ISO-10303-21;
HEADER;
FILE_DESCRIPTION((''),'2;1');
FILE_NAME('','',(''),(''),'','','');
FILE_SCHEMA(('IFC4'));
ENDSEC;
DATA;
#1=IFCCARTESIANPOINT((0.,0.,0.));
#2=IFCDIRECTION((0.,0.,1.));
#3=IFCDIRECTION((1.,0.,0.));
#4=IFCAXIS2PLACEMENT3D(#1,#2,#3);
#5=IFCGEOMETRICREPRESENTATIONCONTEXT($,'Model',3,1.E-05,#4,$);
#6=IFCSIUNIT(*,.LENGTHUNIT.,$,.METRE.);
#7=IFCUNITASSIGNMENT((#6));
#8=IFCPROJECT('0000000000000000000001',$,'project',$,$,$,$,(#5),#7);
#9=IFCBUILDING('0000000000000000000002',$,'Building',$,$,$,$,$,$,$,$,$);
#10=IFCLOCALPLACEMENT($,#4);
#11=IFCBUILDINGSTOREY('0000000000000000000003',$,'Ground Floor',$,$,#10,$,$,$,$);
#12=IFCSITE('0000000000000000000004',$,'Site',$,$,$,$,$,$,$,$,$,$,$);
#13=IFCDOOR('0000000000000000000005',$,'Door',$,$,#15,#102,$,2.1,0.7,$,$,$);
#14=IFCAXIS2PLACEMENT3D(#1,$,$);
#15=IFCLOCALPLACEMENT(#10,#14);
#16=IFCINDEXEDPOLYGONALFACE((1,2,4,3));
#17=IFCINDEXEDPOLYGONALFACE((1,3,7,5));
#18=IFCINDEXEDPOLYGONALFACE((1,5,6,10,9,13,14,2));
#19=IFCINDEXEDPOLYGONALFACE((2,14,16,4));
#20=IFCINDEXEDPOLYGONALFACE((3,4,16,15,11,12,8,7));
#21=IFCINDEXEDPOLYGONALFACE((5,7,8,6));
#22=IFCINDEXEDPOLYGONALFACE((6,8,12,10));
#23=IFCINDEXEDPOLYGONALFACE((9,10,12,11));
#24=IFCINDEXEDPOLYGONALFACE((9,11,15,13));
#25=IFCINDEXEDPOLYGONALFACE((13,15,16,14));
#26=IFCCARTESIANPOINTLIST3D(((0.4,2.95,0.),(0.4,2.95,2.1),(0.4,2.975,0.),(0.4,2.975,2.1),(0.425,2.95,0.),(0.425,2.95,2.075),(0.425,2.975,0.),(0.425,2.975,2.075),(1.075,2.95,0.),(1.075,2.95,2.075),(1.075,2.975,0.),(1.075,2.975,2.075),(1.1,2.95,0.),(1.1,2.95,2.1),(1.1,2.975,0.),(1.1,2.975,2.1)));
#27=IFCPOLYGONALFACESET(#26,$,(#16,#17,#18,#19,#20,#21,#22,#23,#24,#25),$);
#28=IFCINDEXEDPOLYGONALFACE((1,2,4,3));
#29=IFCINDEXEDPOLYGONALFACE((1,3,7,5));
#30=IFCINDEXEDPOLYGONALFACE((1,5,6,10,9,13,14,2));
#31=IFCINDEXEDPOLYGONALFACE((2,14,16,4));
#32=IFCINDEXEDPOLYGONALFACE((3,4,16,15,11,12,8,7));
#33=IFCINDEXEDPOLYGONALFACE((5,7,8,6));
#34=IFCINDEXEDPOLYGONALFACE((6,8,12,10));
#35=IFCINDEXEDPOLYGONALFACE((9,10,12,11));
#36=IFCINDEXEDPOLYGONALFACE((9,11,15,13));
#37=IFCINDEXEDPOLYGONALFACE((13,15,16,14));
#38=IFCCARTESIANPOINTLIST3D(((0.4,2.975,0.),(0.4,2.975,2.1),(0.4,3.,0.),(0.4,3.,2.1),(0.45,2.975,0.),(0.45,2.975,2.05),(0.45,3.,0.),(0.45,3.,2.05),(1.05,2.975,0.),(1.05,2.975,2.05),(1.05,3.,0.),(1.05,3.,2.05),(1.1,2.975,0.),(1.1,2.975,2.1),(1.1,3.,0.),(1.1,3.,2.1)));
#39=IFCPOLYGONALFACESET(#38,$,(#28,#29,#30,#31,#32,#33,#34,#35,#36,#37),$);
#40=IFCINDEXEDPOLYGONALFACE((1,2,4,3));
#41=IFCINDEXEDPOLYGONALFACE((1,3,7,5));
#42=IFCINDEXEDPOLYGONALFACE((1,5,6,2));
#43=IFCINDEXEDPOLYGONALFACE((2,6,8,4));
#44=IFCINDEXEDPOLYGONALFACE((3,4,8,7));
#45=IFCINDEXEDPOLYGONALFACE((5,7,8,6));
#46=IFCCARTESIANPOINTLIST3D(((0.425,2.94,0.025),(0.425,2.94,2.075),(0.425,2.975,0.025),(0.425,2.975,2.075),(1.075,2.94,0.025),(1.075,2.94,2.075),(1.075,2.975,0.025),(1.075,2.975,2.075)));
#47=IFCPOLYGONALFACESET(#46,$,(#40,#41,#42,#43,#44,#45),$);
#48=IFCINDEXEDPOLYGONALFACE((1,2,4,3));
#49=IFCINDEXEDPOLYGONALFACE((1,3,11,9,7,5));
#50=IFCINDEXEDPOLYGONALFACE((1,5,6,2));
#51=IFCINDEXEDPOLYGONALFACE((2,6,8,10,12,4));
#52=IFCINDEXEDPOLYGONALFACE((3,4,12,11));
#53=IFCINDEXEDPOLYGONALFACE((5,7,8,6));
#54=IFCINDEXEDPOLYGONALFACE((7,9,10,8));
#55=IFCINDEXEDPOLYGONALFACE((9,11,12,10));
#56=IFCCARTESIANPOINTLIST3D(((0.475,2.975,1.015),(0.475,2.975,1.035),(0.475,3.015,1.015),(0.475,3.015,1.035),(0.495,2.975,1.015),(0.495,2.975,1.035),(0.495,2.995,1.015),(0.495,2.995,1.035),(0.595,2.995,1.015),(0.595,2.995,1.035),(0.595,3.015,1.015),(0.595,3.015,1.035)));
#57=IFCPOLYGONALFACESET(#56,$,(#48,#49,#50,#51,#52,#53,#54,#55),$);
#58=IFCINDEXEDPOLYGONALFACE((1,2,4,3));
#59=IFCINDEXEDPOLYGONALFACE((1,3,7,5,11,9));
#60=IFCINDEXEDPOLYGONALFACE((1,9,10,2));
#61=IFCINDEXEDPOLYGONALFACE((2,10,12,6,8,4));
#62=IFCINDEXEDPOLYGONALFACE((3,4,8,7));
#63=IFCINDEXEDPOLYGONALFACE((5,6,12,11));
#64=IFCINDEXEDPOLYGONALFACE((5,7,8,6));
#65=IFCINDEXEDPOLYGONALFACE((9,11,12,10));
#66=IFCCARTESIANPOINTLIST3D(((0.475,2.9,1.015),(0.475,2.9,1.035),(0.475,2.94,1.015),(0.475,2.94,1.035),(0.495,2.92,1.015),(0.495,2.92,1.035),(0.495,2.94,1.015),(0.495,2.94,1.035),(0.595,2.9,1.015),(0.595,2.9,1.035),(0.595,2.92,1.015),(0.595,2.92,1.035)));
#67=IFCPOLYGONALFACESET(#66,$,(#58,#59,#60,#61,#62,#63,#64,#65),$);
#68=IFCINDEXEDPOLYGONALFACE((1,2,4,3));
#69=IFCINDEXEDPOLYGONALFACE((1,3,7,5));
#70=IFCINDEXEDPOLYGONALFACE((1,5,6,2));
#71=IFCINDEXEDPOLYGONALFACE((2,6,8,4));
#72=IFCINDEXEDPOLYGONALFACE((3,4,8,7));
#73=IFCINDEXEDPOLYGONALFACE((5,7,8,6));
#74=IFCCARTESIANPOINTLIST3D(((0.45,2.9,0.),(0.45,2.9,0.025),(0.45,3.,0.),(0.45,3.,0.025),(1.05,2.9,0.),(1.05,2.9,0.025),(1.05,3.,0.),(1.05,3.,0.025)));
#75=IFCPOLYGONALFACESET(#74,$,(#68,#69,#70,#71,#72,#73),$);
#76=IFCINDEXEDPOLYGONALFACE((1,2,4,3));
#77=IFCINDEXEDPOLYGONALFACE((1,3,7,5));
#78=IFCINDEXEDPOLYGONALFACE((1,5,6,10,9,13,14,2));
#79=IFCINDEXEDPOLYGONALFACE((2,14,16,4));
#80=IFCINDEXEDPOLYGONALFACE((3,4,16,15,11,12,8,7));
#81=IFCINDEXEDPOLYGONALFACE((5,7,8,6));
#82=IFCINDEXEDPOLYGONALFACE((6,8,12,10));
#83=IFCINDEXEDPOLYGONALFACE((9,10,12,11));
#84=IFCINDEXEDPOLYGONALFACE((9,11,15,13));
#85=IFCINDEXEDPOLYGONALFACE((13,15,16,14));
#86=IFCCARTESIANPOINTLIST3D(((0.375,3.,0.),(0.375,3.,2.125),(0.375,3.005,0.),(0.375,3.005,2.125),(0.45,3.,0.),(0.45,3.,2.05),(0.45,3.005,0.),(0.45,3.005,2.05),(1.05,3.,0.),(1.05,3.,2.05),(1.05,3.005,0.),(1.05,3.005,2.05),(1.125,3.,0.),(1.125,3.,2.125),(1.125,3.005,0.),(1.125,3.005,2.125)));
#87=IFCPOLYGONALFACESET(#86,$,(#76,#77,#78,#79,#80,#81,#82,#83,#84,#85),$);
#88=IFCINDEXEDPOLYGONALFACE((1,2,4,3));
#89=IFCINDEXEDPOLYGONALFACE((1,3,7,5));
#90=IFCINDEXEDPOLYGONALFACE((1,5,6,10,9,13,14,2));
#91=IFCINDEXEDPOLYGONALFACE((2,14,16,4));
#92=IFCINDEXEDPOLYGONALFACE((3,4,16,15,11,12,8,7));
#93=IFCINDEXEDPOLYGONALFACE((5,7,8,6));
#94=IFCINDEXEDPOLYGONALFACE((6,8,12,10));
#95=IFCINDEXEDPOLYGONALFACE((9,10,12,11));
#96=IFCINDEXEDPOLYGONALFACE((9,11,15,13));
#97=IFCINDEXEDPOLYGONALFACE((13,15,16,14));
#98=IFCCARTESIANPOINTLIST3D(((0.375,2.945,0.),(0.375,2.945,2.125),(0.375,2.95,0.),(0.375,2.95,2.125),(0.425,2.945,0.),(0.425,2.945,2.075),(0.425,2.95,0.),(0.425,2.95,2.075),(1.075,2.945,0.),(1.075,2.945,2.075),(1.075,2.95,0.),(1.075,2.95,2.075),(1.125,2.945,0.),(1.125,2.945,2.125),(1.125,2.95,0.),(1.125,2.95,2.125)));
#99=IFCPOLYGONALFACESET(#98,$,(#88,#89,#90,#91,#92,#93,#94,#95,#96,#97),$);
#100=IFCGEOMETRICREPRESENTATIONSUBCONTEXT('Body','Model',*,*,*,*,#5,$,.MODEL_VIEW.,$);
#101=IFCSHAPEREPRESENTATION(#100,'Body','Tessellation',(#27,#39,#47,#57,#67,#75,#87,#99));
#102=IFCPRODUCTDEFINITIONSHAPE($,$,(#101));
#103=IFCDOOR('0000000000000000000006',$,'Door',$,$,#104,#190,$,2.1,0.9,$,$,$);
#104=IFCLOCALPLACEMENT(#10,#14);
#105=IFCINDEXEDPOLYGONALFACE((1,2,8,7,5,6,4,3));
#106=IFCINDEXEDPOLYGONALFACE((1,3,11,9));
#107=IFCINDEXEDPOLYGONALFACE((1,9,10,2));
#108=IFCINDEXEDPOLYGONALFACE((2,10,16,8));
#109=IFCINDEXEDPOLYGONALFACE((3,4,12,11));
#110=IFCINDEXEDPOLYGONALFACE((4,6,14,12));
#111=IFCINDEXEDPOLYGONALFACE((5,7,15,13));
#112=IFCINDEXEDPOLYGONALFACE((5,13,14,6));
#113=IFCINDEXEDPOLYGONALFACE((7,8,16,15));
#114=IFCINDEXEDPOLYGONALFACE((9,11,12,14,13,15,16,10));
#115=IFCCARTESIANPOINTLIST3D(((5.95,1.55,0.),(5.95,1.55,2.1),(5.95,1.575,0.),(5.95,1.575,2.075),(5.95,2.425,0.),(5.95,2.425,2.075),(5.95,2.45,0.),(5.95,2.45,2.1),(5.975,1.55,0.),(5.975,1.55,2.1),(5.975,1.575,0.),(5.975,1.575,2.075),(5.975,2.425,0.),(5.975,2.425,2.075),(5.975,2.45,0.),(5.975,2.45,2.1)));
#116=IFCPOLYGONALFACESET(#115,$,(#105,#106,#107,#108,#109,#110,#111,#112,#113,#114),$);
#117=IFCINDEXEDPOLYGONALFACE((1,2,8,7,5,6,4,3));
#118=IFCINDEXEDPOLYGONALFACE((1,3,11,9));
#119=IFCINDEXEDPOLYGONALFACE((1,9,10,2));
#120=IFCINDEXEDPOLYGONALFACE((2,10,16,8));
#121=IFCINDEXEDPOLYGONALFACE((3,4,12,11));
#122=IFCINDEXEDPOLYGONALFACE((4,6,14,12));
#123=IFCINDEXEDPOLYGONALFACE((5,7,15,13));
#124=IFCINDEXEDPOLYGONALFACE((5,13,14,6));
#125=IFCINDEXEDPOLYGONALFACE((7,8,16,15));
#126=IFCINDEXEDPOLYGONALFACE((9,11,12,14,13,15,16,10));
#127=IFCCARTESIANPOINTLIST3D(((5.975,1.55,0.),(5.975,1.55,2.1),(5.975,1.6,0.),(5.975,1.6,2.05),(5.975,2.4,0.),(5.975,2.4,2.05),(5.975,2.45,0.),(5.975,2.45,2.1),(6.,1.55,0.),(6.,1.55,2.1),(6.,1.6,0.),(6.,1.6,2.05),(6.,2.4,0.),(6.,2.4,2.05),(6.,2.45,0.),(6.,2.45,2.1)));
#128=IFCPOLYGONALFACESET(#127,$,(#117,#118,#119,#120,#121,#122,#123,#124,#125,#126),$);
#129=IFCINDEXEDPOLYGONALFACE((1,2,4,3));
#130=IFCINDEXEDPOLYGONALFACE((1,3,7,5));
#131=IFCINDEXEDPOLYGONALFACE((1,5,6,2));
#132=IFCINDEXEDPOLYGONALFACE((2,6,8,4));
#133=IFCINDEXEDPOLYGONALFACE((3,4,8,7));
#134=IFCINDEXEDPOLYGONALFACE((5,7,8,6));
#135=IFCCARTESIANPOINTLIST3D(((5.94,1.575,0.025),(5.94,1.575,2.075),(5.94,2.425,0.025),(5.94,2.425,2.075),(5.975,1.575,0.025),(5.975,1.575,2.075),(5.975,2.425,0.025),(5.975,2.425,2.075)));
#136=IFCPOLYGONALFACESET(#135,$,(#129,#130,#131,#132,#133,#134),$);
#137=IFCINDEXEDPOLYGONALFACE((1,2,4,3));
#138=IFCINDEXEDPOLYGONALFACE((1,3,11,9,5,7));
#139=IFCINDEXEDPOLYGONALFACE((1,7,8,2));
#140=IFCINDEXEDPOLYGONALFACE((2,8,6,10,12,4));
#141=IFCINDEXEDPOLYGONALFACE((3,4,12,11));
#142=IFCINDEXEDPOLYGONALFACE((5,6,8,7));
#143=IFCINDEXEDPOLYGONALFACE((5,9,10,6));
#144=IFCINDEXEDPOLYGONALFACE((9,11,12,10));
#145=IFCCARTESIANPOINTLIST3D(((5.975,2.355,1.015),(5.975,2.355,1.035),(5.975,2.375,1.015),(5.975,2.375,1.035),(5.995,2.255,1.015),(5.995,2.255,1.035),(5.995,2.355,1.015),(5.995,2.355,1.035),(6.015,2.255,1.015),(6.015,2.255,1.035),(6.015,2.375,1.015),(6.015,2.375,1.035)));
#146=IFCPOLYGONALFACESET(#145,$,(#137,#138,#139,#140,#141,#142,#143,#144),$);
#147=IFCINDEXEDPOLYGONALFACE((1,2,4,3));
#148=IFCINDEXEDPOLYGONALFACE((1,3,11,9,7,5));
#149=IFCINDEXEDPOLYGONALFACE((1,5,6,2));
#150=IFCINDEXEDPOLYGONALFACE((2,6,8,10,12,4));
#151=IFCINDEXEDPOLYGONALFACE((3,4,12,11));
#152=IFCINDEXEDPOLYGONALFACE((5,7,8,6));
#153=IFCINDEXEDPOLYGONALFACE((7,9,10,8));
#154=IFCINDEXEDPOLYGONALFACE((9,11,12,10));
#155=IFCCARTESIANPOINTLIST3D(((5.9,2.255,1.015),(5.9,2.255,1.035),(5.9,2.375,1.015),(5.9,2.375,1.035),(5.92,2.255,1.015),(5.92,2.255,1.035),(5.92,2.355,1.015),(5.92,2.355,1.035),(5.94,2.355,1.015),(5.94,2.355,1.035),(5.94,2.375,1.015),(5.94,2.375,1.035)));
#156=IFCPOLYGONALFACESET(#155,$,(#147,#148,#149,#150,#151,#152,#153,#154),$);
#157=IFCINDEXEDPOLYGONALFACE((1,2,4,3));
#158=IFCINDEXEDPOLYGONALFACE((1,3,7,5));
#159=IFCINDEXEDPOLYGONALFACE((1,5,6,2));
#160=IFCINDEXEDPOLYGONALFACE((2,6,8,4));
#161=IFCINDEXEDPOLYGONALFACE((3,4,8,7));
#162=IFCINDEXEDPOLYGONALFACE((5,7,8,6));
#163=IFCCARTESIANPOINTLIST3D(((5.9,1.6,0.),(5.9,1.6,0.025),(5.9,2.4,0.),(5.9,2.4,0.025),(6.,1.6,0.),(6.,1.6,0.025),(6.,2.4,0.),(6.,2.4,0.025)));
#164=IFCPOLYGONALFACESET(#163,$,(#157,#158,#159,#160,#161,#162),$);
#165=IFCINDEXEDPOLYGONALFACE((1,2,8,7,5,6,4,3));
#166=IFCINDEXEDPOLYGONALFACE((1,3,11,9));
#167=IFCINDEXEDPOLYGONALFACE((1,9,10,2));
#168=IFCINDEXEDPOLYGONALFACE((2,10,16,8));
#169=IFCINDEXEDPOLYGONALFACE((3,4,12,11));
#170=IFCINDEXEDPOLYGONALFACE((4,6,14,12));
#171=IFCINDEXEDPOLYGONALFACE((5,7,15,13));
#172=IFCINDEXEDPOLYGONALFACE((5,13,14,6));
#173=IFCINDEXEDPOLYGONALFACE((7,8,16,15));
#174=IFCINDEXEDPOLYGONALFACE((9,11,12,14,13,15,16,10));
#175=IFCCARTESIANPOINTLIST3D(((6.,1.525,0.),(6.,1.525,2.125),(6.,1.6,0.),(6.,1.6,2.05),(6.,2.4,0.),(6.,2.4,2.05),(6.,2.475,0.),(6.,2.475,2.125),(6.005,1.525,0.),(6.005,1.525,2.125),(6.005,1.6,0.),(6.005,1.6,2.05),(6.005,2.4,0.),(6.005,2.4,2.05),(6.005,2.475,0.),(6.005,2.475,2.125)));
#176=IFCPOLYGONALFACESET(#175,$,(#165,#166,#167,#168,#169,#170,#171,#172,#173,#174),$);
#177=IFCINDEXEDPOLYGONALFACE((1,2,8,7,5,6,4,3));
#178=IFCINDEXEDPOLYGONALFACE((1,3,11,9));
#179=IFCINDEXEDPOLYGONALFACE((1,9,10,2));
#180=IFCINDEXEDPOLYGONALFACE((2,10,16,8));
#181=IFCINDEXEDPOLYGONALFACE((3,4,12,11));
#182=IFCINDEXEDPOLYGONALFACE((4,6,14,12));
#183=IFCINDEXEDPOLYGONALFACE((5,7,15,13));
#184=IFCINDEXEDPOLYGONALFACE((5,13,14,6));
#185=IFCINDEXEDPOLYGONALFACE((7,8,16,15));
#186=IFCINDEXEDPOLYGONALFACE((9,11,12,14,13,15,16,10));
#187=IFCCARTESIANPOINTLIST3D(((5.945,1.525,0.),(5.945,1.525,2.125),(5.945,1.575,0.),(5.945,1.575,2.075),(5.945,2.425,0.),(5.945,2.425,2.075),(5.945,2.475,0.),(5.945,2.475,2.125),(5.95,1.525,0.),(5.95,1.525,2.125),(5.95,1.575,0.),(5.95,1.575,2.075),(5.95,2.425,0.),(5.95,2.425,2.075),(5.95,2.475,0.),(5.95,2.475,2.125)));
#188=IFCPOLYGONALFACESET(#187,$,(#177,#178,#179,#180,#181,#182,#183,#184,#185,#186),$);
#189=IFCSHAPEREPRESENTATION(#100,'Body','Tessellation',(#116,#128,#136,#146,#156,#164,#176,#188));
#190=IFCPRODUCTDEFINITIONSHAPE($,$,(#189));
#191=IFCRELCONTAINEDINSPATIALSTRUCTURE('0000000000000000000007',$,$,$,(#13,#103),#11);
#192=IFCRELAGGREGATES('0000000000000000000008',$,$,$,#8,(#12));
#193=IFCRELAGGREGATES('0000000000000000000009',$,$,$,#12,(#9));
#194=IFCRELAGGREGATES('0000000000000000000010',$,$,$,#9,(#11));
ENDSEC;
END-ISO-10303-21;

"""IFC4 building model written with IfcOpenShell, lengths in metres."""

from ifc_helpers import new_model, si_unit, frame, origin_with_axes, place, context, subcontext, project, spatial, line, indexed_curve, outline, extrude, element, save


model = new_model("IFC4")

# Units and contexts
model_context = context("Model", 3, precision=1e-05, world=origin_with_axes())
body_context = subcontext(model_context, "Body", "Model", "MODEL_VIEW")
ifc_project = project(units=[si_unit("LENGTHUNIT", "METRE")], contexts=[model_context])

# Site, building, storey
site = spatial("IfcSite", under=ifc_project, Name="Site")
building = spatial("IfcBuilding", under=site, Name="Building")
storey_placement = place(None, origin_with_axes())
storey = spatial("IfcBuildingStorey", under=building, at=storey_placement, Name="Ground Floor")

# Doors
door_1_placement = place(storey_placement, frame((1.1, 3.0, 0.0), z_axis=(0.0, 0.0, 1.0), x_axis=(-1.0, 0.0, 0.0)))
element("IfcDoor", 1, at=door_1_placement, inside=storey, Name="Door", OverallHeight=2.1, OverallWidth=0.7, context=body_context, shape_type="SweptSolid", body=[
    extrude(outline(indexed_curve([(0.0, 0.0), (0.0, 2.1), (0.7, 2.1), (0.7, 0.0), (0.675, 0.0), (0.675, 2.075), (0.025, 2.075), (0.025, 0.0)], segments=[line(1, 2, 3, 4, 5, 6, 7, 8, 1)])), frame((0.0, 0.025, 0.0), z_axis=(0.0, -1.0, 0.0), x_axis=(1.0, 0.0, 0.0)), (0.0, 0.0, -1.0), 0.025),
    extrude(outline(indexed_curve([(0.0, 0.0), (0.0, 2.1), (0.7, 2.1), (0.7, 0.0), (0.65, 0.0), (0.65, 2.05), (0.05, 2.05), (0.05, 0.0)], segments=[line(1, 2, 3, 4, 5, 6, 7, 8, 1)])), frame((0.0, 0.0, 0.0), z_axis=(0.0, -1.0, 0.0), x_axis=(1.0, 0.0, 0.0)), (0.0, 0.0, -1.0), 0.025),
    extrude(outline(indexed_curve([(0.0, 0.0), (0.65, 0.0), (0.65, 0.035), (0.0, 0.035)], segments=[line(1, 2, 3, 4, 1)])), frame((0.025, 0.025, 0.025), z_axis=(0.0, 0.0, 1.0), x_axis=(1.0, 0.0, 0.0)), (0.0, 0.0, 1.0), 2.05),
    extrude(outline(indexed_curve([(0.0, 0.0), (0.0, -0.04), (-0.12, -0.04), (-0.12, -0.02), (-0.02, -0.02), (-0.02, 0.0)], segments=[line(1, 2, 3, 4, 5, 6, 1)])), frame((0.625, 0.025, 1.015), z_axis=(0.0, 0.0, 1.0), x_axis=(1.0, 0.0, 0.0)), (0.0, 0.0, 1.0), 0.02),
    extrude(outline(indexed_curve([(0.0, 0.0), (0.0, 0.04), (-0.12, 0.04), (-0.12, 0.02), (-0.02, 0.02), (-0.02, 0.0)], segments=[line(1, 2, 3, 4, 5, 6, 1)])), frame((0.625, 0.06, 1.015), z_axis=(0.0, 0.0, 1.0), x_axis=(1.0, 0.0, 0.0)), (0.0, 0.0, 1.0), 0.02),
    extrude(outline(indexed_curve([(0.0, 0.0), (0.6, 0.0), (0.6, 0.1), (0.0, 0.1)], segments=[line(1, 2, 3, 4, 1)])), frame((0.05, 0.0, 0.0), z_axis=(0.0, 0.0, 1.0), x_axis=(1.0, 0.0, 0.0)), (0.0, 0.0, 1.0), 0.025),
    extrude(outline(indexed_curve([(0.0, 0.0), (0.0, 2.125), (0.75, 2.125), (0.75, 0.0), (0.675, 0.0), (0.675, 2.05), (0.075, 2.05), (0.075, 0.0)], segments=[line(1, 2, 3, 4, 5, 6, 7, 8, 1)])), frame((-0.025, -0.005, 0.0), z_axis=(0.0, -1.0, 0.0), x_axis=(1.0, 0.0, 0.0)), (0.0, 0.0, -1.0), 0.005),
    extrude(outline(indexed_curve([(0.0, 0.0), (0.0, 2.125), (0.75, 2.125), (0.75, 0.0), (0.7, 0.0), (0.7, 2.075), (0.05, 2.075), (0.05, 0.0)], segments=[line(1, 2, 3, 4, 5, 6, 7, 8, 1)])), frame((-0.025, 0.05, 0.0), z_axis=(0.0, -1.0, 0.0), x_axis=(1.0, 0.0, 0.0)), (0.0, 0.0, -1.0), 0.005),
])
door_2_placement = place(storey_placement, frame((6.0, 1.55, 0.0), z_axis=(0.0, 0.0, 1.0), x_axis=(0.0, 1.0, 0.0)))
element("IfcDoor", 2, at=door_2_placement, inside=storey, Name="Door", OverallHeight=2.1, OverallWidth=0.9, context=body_context, shape_type="SweptSolid", body=[
    extrude(outline(indexed_curve([(0.0, 0.0), (0.0, 2.1), (0.9, 2.1), (0.9, 0.0), (0.875, 0.0), (0.875, 2.075), (0.025, 2.075), (0.025, 0.0)], segments=[line(1, 2, 3, 4, 5, 6, 7, 8, 1)])), frame((0.0, 0.025, 0.0), z_axis=(0.0, -1.0, 0.0), x_axis=(1.0, 0.0, 0.0)), (0.0, 0.0, -1.0), 0.025),
    extrude(outline(indexed_curve([(0.0, 0.0), (0.0, 2.1), (0.9, 2.1), (0.9, 0.0), (0.85, 0.0), (0.85, 2.05), (0.05, 2.05), (0.05, 0.0)], segments=[line(1, 2, 3, 4, 5, 6, 7, 8, 1)])), frame((0.0, 0.0, 0.0), z_axis=(0.0, -1.0, 0.0), x_axis=(1.0, 0.0, 0.0)), (0.0, 0.0, -1.0), 0.025),
    extrude(outline(indexed_curve([(0.0, 0.0), (0.85, 0.0), (0.85, 0.035), (0.0, 0.035)], segments=[line(1, 2, 3, 4, 1)])), frame((0.025, 0.025, 0.025), z_axis=(0.0, 0.0, 1.0), x_axis=(1.0, 0.0, 0.0)), (0.0, 0.0, 1.0), 2.05),
    extrude(outline(indexed_curve([(0.0, 0.0), (0.0, -0.04), (-0.12, -0.04), (-0.12, -0.02), (-0.02, -0.02), (-0.02, 0.0)], segments=[line(1, 2, 3, 4, 5, 6, 1)])), frame((0.825, 0.025, 1.015), z_axis=(0.0, 0.0, 1.0), x_axis=(1.0, 0.0, 0.0)), (0.0, 0.0, 1.0), 0.02),
    extrude(outline(indexed_curve([(0.0, 0.0), (0.0, 0.04), (-0.12, 0.04), (-0.12, 0.02), (-0.02, 0.02), (-0.02, 0.0)], segments=[line(1, 2, 3, 4, 5, 6, 1)])), frame((0.825, 0.06, 1.015), z_axis=(0.0, 0.0, 1.0), x_axis=(1.0, 0.0, 0.0)), (0.0, 0.0, 1.0), 0.02),
    extrude(outline(indexed_curve([(0.0, 0.0), (0.8, 0.0), (0.8, 0.1), (0.0, 0.1)], segments=[line(1, 2, 3, 4, 1)])), frame((0.05, 0.0, 0.0), z_axis=(0.0, 0.0, 1.0), x_axis=(1.0, 0.0, 0.0)), (0.0, 0.0, 1.0), 0.025),
    extrude(outline(indexed_curve([(0.0, 0.0), (0.0, 2.125), (0.95, 2.125), (0.95, 0.0), (0.875, 0.0), (0.875, 2.05), (0.075, 2.05), (0.075, 0.0)], segments=[line(1, 2, 3, 4, 5, 6, 7, 8, 1)])), frame((-0.025, -0.005, 0.0), z_axis=(0.0, -1.0, 0.0), x_axis=(1.0, 0.0, 0.0)), (0.0, 0.0, -1.0), 0.005),
    extrude(outline(indexed_curve([(0.0, 0.0), (0.0, 2.125), (0.95, 2.125), (0.95, 0.0), (0.9, 0.0), (0.9, 2.075), (0.05, 2.075), (0.05, 0.0)], segments=[line(1, 2, 3, 4, 5, 6, 7, 8, 1)])), frame((-0.025, 0.05, 0.0), z_axis=(0.0, -1.0, 0.0), x_axis=(1.0, 0.0, 0.0)), (0.0, 0.0, -1.0), 0.005),
])

save(model, "model.ifc")
